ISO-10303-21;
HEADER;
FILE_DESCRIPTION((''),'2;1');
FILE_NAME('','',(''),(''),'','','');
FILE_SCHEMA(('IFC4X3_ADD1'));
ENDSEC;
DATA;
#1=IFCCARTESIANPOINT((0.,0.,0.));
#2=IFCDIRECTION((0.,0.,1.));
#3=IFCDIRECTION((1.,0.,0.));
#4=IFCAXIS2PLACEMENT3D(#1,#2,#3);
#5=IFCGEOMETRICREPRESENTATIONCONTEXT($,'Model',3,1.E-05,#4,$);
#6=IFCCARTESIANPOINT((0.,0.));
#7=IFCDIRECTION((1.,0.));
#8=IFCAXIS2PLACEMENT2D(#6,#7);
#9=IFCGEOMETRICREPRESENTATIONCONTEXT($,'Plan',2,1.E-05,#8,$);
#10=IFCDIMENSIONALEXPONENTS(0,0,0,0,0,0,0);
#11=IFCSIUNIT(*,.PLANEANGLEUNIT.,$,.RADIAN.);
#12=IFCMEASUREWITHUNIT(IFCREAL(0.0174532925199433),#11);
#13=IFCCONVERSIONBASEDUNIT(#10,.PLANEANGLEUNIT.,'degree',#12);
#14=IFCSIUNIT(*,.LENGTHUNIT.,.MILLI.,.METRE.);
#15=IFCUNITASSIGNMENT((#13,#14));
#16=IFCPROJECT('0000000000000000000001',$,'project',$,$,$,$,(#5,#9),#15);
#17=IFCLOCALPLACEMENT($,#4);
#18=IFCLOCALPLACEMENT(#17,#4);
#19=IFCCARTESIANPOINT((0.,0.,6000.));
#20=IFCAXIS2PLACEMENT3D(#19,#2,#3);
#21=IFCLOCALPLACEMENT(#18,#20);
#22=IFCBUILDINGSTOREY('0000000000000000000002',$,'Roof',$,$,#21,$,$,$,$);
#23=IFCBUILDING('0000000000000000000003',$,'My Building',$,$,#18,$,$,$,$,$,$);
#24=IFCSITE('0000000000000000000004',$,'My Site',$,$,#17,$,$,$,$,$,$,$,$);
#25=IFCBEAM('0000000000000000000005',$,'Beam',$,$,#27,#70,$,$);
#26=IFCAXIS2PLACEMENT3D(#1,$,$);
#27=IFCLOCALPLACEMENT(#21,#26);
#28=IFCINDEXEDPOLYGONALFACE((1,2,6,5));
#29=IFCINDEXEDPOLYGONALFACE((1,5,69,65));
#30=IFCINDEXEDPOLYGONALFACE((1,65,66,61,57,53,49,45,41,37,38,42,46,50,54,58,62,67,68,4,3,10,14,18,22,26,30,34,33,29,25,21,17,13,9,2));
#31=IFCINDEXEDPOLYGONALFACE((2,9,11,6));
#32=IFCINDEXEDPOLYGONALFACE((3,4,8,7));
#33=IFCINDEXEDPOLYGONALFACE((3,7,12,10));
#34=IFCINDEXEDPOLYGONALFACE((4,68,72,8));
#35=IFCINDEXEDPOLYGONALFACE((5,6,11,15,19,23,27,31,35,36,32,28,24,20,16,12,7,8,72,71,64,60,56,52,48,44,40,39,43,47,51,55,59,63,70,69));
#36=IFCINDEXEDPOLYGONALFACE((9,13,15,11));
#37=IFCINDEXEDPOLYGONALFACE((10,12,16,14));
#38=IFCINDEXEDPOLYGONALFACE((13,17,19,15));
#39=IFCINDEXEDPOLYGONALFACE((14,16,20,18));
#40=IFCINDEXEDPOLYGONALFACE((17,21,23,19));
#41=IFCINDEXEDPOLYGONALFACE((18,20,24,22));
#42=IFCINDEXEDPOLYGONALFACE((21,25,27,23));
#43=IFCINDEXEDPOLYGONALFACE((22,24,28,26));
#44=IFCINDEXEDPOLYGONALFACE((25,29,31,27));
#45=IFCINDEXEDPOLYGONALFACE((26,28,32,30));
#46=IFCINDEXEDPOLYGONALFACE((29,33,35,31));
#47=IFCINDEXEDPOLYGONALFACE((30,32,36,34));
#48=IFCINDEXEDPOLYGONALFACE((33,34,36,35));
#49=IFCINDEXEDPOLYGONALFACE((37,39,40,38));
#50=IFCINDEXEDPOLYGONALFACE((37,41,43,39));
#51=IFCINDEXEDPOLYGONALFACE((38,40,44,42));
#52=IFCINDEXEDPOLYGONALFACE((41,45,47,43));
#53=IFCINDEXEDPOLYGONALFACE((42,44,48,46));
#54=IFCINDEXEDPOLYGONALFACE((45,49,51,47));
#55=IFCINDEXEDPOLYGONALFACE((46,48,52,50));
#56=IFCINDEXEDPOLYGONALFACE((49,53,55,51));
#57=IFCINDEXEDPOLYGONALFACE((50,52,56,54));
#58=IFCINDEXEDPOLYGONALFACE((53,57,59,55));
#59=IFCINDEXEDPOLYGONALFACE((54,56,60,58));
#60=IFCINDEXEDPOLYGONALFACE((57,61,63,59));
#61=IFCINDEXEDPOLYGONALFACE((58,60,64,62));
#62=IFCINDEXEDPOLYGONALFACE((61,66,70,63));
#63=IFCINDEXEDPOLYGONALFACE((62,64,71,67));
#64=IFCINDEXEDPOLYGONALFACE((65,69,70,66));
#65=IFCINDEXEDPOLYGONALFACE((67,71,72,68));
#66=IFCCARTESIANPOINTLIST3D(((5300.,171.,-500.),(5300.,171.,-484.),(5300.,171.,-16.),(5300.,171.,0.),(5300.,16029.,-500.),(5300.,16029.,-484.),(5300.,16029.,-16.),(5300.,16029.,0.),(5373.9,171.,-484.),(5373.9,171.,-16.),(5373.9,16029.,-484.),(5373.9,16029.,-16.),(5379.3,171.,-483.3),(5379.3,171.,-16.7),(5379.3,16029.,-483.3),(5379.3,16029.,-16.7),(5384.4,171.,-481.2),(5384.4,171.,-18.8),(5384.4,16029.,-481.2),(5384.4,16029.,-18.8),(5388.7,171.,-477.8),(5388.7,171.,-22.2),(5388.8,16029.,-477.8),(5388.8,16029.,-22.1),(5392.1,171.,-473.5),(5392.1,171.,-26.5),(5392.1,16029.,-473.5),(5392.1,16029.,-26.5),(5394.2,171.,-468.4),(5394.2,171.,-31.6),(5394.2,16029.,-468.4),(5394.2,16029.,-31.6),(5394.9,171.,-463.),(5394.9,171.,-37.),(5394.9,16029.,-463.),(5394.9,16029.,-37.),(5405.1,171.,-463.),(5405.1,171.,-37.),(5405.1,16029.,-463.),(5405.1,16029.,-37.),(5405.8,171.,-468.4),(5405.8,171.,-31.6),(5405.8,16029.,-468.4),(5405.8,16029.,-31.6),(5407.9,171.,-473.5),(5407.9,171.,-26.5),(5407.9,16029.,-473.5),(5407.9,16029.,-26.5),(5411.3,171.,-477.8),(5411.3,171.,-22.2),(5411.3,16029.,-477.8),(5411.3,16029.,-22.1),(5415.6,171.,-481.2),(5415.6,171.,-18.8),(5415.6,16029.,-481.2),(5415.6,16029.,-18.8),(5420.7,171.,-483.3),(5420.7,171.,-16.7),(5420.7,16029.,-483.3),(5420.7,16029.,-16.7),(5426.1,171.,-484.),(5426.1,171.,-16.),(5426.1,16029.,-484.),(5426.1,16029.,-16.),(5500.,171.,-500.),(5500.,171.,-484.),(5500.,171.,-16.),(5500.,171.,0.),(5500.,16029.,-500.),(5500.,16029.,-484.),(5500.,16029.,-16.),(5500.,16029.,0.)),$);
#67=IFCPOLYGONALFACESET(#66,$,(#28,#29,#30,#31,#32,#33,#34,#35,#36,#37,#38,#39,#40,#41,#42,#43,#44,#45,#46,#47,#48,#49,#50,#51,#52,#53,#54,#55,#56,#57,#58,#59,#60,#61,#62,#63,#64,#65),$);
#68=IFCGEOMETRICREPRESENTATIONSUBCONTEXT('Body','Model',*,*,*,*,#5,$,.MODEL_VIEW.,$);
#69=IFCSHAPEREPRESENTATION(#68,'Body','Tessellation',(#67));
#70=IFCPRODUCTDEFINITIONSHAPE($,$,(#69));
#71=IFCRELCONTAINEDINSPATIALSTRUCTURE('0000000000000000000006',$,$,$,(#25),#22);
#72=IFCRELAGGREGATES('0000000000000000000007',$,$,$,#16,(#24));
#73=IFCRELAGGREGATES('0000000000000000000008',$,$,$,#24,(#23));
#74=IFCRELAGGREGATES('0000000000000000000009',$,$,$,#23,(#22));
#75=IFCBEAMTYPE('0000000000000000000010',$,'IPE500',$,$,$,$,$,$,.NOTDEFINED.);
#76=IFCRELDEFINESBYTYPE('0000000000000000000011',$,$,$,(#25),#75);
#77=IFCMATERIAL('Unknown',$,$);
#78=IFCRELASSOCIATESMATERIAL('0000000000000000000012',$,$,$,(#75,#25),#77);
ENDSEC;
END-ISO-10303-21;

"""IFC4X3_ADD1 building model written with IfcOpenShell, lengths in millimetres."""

from ifc_helpers import new_model, entity, si_unit, converted_unit, frame, origin_with_axes, origin_2d_with_axis, place, context, subcontext, project, spatial, i_section, extrude, material, material_profile, profile_set, profile_usage, type_object, element, save


model = new_model("IFC4X3_ADD1")

# Units and contexts
model_context = context("Model", 3, precision=1e-05, world=origin_with_axes())
plan_context = context("Plan", 2, precision=1e-05, world=origin_2d_with_axis())
body_context = subcontext(model_context, "Body", "Model", "MODEL_VIEW")
ifc_project = project(units=[converted_unit("PLANEANGLEUNIT", "degree", entity("IfcReal", 0.0174532925199433), si_unit("PLANEANGLEUNIT", "RADIAN"), dimensions=[0, 0, 0, 0, 0, 0, 0]), si_unit("LENGTHUNIT", "METRE", prefix="MILLI")], contexts=[model_context, plan_context])

# Site, building, storey
site_placement = place(None, origin_with_axes())
site = spatial("IfcSite", under=ifc_project, at=site_placement, Name="My Site")
building_placement = place(site_placement, origin_with_axes())
building = spatial("IfcBuilding", under=site, at=building_placement, Name="My Building")
storey_placement = place(building_placement, frame((0.0, 0.0, 6000.0), z_axis=(0.0, 0.0, 1.0), x_axis=(1.0, 0.0, 0.0)))
storey = spatial("IfcBuildingStorey", under=building, at=storey_placement, Name="Roof")

# Beam
ifc_material = material(Name="Unknown")
ifc_material_profile_1 = material_profile(ifc_material, i_section(OverallWidth=200.0, OverallDepth=500.0, WebThickness=10.2, FlangeThickness=16.0, FilletRadius=21.0))
ifc_profile_set_1 = profile_set([ifc_material_profile_1])
ifc_profile_usage_1 = profile_usage(ifc_profile_set_1, cardinal=8)
beam_type_1 = type_object("IfcBeamType", Name="IPE500", PredefinedType="NOTDEFINED", material=ifc_profile_set_1)
beam_1_placement = place(storey_placement, frame((5400.0, 171.0, 0.0), z_axis=(0.0, 1.0, 0.0), x_axis=(-1.0, 0.0, 0.0)))
element("IfcBeam", 1, at=beam_1_placement, inside=storey, type_object=beam_type_1, material=ifc_profile_usage_1, Name="Beam", context=body_context, shape_type="SweptSolid", body=[
    extrude(i_section(OverallWidth=200.0, OverallDepth=500.0, WebThickness=10.2, FlangeThickness=16.0, FilletRadius=21.0), frame((0.0, -250.0, 0.0), z_axis=(0.0, 0.0, 1.0), x_axis=(1.0, 0.0, 0.0)), (0.0, 0.0, 1.0), 15858.0),
])

save(model, "model.ifc")
